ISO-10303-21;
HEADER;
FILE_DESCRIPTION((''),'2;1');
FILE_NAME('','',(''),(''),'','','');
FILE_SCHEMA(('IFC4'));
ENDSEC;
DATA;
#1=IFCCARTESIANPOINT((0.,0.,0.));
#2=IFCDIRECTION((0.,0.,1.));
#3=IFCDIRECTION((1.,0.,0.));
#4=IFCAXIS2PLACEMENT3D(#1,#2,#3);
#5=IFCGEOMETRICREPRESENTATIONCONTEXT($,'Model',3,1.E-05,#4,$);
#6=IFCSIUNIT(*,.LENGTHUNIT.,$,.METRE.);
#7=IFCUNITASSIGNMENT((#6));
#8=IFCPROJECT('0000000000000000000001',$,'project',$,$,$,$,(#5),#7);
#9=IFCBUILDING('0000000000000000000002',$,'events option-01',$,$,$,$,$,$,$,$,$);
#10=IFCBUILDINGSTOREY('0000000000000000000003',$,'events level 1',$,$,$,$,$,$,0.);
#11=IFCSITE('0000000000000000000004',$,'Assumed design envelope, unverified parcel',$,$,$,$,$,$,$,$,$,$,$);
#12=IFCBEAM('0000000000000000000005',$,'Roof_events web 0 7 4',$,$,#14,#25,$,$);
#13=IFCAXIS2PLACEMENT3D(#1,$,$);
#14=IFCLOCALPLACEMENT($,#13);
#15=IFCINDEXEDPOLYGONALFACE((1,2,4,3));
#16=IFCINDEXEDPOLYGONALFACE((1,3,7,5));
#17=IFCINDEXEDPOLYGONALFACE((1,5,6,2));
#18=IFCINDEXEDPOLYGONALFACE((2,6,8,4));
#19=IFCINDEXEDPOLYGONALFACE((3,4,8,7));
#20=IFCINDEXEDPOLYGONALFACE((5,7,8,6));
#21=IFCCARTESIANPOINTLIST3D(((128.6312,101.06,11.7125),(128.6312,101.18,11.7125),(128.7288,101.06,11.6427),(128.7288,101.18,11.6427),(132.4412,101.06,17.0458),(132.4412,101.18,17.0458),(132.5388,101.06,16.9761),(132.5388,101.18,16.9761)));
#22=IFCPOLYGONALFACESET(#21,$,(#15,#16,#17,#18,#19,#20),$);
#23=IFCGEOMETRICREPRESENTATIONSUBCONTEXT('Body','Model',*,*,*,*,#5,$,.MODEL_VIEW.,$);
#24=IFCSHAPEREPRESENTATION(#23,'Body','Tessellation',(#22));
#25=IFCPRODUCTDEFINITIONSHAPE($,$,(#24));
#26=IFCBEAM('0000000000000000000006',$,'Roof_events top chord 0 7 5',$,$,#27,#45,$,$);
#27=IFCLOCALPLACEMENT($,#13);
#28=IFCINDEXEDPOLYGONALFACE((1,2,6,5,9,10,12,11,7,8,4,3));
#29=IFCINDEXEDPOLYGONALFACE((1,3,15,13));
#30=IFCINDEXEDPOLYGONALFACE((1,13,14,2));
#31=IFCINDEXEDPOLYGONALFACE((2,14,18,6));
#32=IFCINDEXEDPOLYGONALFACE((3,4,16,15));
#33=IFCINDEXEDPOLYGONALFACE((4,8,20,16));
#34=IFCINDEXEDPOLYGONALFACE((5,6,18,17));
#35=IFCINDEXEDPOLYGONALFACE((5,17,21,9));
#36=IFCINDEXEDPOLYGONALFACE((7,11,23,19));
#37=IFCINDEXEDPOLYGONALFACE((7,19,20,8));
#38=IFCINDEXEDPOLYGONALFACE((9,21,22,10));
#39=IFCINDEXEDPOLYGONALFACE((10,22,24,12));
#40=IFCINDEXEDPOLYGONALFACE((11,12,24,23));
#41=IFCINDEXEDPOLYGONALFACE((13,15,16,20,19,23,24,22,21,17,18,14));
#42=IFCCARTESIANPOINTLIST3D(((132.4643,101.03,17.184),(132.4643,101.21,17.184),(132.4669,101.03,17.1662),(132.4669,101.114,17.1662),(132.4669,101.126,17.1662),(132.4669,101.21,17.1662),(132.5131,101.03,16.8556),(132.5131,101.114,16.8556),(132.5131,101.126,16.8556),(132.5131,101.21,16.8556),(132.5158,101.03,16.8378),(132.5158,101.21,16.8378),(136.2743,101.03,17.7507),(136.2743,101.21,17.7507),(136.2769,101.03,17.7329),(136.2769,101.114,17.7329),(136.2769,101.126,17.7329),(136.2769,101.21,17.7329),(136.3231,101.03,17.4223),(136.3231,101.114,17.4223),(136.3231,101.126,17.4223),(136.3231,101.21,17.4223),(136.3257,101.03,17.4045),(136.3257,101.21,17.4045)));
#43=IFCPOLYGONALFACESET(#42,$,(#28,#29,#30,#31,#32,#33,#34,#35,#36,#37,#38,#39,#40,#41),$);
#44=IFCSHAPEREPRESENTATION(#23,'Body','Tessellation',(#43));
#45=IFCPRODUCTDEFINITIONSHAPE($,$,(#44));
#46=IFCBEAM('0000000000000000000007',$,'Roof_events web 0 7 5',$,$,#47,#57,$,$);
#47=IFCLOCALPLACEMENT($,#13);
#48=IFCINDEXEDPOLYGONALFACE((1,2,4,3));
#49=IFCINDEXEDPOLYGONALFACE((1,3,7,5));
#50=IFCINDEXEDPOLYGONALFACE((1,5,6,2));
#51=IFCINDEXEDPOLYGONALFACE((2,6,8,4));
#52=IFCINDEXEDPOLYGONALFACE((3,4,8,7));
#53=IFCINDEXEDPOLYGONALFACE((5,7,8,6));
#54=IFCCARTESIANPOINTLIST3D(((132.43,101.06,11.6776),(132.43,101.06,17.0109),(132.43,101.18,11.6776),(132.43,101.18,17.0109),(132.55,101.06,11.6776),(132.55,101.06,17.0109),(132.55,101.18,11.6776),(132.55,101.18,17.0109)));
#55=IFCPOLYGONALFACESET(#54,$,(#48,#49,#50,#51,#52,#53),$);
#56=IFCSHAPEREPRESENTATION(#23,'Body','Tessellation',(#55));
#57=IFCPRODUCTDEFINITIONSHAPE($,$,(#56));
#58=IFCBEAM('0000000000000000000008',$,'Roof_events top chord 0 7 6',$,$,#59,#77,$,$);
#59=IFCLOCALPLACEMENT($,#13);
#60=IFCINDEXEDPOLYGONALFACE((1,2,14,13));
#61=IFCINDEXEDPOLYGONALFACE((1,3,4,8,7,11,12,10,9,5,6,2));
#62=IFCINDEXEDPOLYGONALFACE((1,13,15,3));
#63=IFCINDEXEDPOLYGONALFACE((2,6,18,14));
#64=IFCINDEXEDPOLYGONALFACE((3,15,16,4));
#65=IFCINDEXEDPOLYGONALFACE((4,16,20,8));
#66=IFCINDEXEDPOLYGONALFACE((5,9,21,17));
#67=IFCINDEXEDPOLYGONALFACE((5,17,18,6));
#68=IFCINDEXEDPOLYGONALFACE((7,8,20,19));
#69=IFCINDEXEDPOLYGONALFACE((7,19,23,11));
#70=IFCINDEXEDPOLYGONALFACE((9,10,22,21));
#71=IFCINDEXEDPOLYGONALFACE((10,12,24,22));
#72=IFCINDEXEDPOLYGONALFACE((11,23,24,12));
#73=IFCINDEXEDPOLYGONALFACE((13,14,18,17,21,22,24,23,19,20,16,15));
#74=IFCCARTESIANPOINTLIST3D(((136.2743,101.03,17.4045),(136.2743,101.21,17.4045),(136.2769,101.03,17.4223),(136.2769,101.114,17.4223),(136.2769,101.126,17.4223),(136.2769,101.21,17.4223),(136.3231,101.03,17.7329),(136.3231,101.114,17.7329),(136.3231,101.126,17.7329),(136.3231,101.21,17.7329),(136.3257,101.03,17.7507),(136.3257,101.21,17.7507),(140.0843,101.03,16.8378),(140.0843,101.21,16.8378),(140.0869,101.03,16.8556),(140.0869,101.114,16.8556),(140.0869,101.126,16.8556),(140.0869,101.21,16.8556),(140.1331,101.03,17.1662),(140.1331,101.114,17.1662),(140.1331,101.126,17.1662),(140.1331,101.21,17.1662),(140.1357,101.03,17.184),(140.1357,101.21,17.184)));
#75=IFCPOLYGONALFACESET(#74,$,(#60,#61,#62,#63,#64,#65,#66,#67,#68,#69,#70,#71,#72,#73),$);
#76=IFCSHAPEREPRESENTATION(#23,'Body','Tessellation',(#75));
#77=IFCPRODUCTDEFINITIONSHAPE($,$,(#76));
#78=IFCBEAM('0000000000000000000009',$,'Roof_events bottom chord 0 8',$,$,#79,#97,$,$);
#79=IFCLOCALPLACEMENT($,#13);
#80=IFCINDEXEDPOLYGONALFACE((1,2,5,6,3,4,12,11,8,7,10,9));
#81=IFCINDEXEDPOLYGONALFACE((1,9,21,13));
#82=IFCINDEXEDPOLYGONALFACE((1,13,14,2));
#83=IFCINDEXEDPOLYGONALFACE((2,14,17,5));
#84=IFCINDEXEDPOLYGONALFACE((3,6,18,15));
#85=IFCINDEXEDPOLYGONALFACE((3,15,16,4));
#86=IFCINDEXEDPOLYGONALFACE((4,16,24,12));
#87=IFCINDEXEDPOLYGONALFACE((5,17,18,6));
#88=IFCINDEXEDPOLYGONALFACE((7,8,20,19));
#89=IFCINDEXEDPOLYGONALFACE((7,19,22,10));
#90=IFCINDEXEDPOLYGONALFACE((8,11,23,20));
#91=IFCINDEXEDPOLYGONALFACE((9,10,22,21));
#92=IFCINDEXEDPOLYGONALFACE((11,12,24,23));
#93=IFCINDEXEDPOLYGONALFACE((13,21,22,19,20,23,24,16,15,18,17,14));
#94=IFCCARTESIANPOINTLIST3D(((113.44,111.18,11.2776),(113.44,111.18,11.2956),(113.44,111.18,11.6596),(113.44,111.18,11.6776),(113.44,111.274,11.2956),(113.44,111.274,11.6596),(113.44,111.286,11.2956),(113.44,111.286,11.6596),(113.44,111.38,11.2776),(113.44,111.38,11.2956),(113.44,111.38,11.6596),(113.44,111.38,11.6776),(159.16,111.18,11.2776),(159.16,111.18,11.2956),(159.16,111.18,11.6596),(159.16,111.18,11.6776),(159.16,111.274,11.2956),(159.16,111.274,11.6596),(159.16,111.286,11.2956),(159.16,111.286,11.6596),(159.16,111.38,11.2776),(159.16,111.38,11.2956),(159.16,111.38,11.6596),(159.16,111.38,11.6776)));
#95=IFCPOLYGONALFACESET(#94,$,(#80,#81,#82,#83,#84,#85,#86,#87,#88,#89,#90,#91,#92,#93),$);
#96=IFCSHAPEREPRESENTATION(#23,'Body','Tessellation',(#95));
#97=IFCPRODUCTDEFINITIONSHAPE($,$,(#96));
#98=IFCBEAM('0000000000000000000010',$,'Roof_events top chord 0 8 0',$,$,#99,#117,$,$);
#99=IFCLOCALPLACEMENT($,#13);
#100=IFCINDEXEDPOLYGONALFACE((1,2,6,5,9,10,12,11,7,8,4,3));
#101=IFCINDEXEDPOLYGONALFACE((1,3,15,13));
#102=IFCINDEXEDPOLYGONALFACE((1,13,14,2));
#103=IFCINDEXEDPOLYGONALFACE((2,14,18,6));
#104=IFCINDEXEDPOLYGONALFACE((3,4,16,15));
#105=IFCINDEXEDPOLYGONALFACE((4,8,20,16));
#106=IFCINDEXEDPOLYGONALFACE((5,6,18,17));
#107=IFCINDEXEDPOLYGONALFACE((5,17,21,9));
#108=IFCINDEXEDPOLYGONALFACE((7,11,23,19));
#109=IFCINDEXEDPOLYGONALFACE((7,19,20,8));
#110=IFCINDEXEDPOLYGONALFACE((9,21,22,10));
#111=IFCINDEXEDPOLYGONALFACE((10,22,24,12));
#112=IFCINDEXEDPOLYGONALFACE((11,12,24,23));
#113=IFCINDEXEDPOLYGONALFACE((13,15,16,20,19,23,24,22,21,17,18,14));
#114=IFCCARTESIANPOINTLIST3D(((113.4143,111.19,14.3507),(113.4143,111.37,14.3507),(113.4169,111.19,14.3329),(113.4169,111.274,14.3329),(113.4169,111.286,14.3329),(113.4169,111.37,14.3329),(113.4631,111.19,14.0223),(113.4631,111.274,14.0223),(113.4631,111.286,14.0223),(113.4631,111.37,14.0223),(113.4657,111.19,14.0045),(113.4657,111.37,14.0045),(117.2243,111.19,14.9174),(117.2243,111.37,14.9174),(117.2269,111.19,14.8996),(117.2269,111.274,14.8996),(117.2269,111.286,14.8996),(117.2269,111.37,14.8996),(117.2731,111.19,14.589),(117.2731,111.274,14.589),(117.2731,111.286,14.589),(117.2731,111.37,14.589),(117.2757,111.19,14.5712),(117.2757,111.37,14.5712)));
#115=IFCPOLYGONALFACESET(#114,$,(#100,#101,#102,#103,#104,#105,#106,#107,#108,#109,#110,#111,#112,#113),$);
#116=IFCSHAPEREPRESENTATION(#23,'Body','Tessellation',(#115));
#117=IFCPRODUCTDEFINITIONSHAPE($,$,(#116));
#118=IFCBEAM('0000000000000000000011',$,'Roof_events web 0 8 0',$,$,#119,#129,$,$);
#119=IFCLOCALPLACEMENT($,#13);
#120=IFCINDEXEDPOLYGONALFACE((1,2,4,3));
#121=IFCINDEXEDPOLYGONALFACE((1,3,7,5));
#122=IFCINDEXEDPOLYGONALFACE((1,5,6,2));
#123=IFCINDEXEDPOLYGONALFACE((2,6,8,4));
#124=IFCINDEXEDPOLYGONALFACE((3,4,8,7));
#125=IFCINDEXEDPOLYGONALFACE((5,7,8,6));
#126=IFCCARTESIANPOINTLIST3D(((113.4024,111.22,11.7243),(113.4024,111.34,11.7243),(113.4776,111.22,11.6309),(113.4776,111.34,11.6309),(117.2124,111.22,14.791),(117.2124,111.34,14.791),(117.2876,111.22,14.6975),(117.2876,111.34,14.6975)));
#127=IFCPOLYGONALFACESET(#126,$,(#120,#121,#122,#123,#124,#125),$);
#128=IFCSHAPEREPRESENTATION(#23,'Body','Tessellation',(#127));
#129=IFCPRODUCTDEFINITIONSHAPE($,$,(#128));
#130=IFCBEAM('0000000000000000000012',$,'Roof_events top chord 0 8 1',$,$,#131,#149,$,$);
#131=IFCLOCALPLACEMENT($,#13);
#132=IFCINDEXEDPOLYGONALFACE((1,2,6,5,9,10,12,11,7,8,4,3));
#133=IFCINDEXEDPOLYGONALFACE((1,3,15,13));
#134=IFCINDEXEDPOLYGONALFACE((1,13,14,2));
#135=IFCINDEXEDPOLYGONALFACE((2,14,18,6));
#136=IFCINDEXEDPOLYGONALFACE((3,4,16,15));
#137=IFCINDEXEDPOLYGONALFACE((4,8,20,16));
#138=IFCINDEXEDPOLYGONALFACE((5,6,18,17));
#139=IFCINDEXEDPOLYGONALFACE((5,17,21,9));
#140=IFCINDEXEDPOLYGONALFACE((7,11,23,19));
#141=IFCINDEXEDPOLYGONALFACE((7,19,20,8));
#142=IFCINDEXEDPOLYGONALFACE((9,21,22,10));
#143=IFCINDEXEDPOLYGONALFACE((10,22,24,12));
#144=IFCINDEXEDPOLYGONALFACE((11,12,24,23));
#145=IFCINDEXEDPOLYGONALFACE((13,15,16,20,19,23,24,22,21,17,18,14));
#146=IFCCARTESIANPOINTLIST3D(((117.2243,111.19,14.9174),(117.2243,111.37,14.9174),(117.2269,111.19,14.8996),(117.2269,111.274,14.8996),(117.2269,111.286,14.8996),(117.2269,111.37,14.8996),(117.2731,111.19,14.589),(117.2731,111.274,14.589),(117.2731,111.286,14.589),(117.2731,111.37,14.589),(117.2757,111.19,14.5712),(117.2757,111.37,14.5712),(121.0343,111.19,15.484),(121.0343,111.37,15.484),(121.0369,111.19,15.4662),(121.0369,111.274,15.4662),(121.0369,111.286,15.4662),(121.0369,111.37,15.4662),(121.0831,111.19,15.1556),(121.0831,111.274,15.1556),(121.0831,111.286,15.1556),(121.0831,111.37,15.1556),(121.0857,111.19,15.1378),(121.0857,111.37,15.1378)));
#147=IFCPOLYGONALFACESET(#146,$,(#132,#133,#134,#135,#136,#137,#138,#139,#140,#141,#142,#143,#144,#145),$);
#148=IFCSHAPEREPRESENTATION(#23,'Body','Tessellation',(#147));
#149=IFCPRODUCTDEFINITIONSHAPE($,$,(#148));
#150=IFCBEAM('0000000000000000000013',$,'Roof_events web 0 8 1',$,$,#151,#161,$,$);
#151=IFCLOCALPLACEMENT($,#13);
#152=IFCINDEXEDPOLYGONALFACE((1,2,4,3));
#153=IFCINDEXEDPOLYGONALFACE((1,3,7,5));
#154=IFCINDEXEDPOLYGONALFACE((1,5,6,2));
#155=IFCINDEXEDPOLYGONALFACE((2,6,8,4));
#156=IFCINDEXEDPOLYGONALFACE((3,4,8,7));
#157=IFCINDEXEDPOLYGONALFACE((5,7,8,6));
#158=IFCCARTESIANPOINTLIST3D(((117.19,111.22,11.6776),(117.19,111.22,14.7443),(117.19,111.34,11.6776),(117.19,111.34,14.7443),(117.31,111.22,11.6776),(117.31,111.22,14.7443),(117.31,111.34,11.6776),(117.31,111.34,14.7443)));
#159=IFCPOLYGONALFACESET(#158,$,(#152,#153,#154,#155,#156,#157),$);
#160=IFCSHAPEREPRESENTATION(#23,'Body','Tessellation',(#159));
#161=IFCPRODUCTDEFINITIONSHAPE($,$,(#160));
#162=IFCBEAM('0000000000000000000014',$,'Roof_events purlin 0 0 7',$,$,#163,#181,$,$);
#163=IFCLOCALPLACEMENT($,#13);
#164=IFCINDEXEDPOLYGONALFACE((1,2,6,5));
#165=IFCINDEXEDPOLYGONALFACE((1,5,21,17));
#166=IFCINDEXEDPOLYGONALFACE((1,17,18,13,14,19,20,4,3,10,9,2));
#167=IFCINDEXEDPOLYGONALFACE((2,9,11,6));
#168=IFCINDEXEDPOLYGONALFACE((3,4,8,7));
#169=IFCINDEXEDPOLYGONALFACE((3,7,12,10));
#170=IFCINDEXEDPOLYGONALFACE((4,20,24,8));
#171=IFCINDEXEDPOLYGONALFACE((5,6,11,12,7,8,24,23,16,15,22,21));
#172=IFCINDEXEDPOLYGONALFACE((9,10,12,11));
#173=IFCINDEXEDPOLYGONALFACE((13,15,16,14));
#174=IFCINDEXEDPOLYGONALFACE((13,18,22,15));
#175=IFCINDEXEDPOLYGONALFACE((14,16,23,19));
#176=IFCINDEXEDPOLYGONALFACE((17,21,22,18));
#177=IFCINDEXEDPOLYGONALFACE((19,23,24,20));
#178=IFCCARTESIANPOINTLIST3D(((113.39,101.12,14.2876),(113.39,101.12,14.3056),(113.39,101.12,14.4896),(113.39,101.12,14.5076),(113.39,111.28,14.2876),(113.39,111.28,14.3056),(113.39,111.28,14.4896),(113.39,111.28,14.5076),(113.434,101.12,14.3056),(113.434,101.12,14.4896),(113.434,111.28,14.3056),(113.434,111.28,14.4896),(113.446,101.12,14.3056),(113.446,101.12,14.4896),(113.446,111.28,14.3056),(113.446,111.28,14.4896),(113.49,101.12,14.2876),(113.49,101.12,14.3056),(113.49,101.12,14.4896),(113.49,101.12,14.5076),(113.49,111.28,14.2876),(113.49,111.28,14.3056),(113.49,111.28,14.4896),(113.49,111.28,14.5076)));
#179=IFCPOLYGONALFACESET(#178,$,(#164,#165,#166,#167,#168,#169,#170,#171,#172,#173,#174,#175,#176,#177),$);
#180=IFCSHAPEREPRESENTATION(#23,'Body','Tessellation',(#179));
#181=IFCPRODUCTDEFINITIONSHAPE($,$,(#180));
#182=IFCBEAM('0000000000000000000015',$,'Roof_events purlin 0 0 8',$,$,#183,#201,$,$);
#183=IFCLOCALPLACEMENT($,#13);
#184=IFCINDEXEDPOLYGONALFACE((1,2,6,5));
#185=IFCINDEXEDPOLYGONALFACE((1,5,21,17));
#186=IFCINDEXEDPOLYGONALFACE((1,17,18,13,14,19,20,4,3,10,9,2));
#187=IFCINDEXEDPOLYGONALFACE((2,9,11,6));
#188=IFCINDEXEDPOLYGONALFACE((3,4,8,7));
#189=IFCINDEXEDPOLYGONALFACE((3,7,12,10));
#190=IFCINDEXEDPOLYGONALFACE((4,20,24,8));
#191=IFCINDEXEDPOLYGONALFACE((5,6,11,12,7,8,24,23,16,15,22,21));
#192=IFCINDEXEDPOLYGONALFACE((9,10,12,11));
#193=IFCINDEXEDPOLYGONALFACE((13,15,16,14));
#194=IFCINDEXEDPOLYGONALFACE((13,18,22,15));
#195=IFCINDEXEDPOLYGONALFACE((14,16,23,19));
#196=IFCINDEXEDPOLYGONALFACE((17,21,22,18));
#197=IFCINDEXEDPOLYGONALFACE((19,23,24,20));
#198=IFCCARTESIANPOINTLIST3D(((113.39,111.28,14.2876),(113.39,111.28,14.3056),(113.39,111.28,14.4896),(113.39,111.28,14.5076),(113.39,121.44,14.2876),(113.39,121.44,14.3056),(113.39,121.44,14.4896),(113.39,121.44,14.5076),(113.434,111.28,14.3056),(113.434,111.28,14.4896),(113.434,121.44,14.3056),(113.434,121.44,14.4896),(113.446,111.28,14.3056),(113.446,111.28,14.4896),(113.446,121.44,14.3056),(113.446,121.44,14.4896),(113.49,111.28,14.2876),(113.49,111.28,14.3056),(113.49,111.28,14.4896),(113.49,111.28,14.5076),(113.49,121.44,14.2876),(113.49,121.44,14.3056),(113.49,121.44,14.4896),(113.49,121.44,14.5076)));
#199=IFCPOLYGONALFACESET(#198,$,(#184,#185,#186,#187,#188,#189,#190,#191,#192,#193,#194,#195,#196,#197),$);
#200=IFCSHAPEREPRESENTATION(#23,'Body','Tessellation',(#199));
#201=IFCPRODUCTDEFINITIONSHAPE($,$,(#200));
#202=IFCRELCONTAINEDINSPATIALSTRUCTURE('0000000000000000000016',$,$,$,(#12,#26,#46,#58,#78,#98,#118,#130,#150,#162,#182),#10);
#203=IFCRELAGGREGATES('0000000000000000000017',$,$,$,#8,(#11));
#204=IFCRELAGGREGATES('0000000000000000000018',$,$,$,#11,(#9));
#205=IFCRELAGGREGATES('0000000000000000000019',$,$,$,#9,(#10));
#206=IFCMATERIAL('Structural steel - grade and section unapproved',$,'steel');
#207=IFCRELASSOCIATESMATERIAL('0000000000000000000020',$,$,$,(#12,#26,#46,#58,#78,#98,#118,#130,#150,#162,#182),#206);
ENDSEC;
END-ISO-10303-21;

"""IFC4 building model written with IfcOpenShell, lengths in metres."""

from ifc_helpers import new_model, si_unit, frame, origin_with_axes, place, context, subcontext, project, spatial, rectangle, i_section, extrude, material, element, save


model = new_model("IFC4")

# Units and contexts
model_context = context("Model", 3, precision=1e-05, world=origin_with_axes())
body_context = subcontext(model_context, "Body", "Model", "MODEL_VIEW")
ifc_project = project(units=[si_unit("LENGTHUNIT", "METRE")], contexts=[model_context])

# Site, building, storey
site = spatial("IfcSite", under=ifc_project, Name="Assumed design envelope, unverified parcel")
building = spatial("IfcBuilding", under=site, Name="events option-01")
storey = spatial("IfcBuildingStorey", under=building, Name="events level 1", Elevation=0.0)

# Shared definitions
ifc_material_1 = material(Name="Structural steel - grade and section unapproved", Category="steel")

# Beams
beam_1_placement = place(None, frame((128.68, 101.12, 11.6776), z_axis=(0.581288, 0.0, 0.813698), x_axis=(0.0, 1.0, 0.0)))
element("IfcBeam", 1, at=beam_1_placement, inside=storey, material=ifc_material_1, Name="Roof_events web 0 7 4", context=body_context, shape_type="SweptSolid", body=[
    extrude(rectangle(XDim=0.12, YDim=0.12), origin_with_axes(), (0.0, 0.0, 1.0), 6.5544),
])
beam_2_placement = place(None, frame((132.49, 101.12, 17.0109), z_axis=(0.98912, 0.0, 0.147113), x_axis=(0.0, 1.0, 0.0)))
element("IfcBeam", 2, at=beam_2_placement, inside=storey, material=ifc_material_1, Name="Roof_events top chord 0 7 5", context=body_context, shape_type="SweptSolid", body=[
    extrude(i_section(OverallWidth=0.18, OverallDepth=0.35, WebThickness=0.012, FlangeThickness=0.018, FilletRadius=0.0), origin_with_axes(), (0.0, 0.0, 1.0), 3.8519),
])
beam_3_placement = place(None, frame((132.49, 101.12, 11.6776), z_axis=(0.0, 0.0, 1.0), x_axis=(-1.0, 0.0, 0.0)))
element("IfcBeam", 3, at=beam_3_placement, inside=storey, material=ifc_material_1, Name="Roof_events web 0 7 5", context=body_context, shape_type="SweptSolid", body=[
    extrude(rectangle(XDim=0.12, YDim=0.12), origin_with_axes(), (0.0, 0.0, 1.0), 5.3333),
])
beam_4_placement = place(None, frame((136.3, 101.12, 17.5776), z_axis=(0.98912, 0.0, -0.147113), x_axis=(0.0, 1.0, 0.0)))
element("IfcBeam", 4, at=beam_4_placement, inside=storey, material=ifc_material_1, Name="Roof_events top chord 0 7 6", context=body_context, shape_type="SweptSolid", body=[
    extrude(i_section(OverallWidth=0.18, OverallDepth=0.35, WebThickness=0.012, FlangeThickness=0.018, FilletRadius=0.0), origin_with_axes(), (0.0, 0.0, 1.0), 3.8519),
])
beam_5_placement = place(None, frame((113.44, 111.28, 11.4776), z_axis=(1.0, 0.0, 0.0), x_axis=(0.0, 1.0, 0.0)))
element("IfcBeam", 5, at=beam_5_placement, inside=storey, material=ifc_material_1, Name="Roof_events bottom chord 0 8", context=body_context, shape_type="SweptSolid", body=[
    extrude(i_section(OverallWidth=0.2, OverallDepth=0.4, WebThickness=0.012, FlangeThickness=0.018, FilletRadius=0.0), origin_with_axes(), (0.0, 0.0, 1.0), 45.72),
])
beam_6_placement = place(None, frame((113.44, 111.28, 14.1776), z_axis=(0.98912, 0.0, 0.147113), x_axis=(0.0, 1.0, 0.0)))
element("IfcBeam", 6, at=beam_6_placement, inside=storey, material=ifc_material_1, Name="Roof_events top chord 0 8 0", context=body_context, shape_type="SweptSolid", body=[
    extrude(i_section(OverallWidth=0.18, OverallDepth=0.35, WebThickness=0.012, FlangeThickness=0.018, FilletRadius=0.0), origin_with_axes(), (0.0, 0.0, 1.0), 3.8519),
])
beam_7_placement = place(None, frame((113.44, 111.28, 11.6776), z_axis=(0.779003, 0.0, 0.62702), x_axis=(0.0, 1.0, 0.0)))
element("IfcBeam", 7, at=beam_7_placement, inside=storey, material=ifc_material_1, Name="Roof_events web 0 8 0", context=body_context, shape_type="SweptSolid", body=[
    extrude(rectangle(XDim=0.12, YDim=0.12), origin_with_axes(), (0.0, 0.0, 1.0), 4.8909),
])
beam_8_placement = place(None, frame((117.25, 111.28, 14.7443), z_axis=(0.98912, 0.0, 0.147113), x_axis=(0.0, 1.0, 0.0)))
element("IfcBeam", 8, at=beam_8_placement, inside=storey, material=ifc_material_1, Name="Roof_events top chord 0 8 1", context=body_context, shape_type="SweptSolid", body=[
    extrude(i_section(OverallWidth=0.18, OverallDepth=0.35, WebThickness=0.012, FlangeThickness=0.018, FilletRadius=0.0), origin_with_axes(), (0.0, 0.0, 1.0), 3.8519),
])
beam_9_placement = place(None, frame((117.25, 111.28, 11.6776), z_axis=(0.0, 0.0, 1.0), x_axis=(-1.0, 0.0, 0.0)))
element("IfcBeam", 9, at=beam_9_placement, inside=storey, material=ifc_material_1, Name="Roof_events web 0 8 1", context=body_context, shape_type="SweptSolid", body=[
    extrude(rectangle(XDim=0.12, YDim=0.12), origin_with_axes(), (0.0, 0.0, 1.0), 3.0667),
])
beam_10_placement = place(None, frame((113.44, 101.12, 14.3976), z_axis=(0.0, 1.0, 0.0), x_axis=(-1.0, 0.0, 0.0)))
element("IfcBeam", 10, at=beam_10_placement, inside=storey, material=ifc_material_1, Name="Roof_events purlin 0 0 7", context=body_context, shape_type="SweptSolid", body=[
    extrude(i_section(OverallWidth=0.1, OverallDepth=0.22, WebThickness=0.012, FlangeThickness=0.018, FilletRadius=0.0), origin_with_axes(), (0.0, 0.0, 1.0), 10.16),
])
beam_11_placement = place(None, frame((113.44, 111.28, 14.3976), z_axis=(0.0, 1.0, 0.0), x_axis=(-1.0, 0.0, 0.0)))
element("IfcBeam", 11, at=beam_11_placement, inside=storey, material=ifc_material_1, Name="Roof_events purlin 0 0 8", context=body_context, shape_type="SweptSolid", body=[
    extrude(i_section(OverallWidth=0.1, OverallDepth=0.22, WebThickness=0.012, FlangeThickness=0.018, FilletRadius=0.0), origin_with_axes(), (0.0, 0.0, 1.0), 10.16),
])

save(model, "model.ifc")
